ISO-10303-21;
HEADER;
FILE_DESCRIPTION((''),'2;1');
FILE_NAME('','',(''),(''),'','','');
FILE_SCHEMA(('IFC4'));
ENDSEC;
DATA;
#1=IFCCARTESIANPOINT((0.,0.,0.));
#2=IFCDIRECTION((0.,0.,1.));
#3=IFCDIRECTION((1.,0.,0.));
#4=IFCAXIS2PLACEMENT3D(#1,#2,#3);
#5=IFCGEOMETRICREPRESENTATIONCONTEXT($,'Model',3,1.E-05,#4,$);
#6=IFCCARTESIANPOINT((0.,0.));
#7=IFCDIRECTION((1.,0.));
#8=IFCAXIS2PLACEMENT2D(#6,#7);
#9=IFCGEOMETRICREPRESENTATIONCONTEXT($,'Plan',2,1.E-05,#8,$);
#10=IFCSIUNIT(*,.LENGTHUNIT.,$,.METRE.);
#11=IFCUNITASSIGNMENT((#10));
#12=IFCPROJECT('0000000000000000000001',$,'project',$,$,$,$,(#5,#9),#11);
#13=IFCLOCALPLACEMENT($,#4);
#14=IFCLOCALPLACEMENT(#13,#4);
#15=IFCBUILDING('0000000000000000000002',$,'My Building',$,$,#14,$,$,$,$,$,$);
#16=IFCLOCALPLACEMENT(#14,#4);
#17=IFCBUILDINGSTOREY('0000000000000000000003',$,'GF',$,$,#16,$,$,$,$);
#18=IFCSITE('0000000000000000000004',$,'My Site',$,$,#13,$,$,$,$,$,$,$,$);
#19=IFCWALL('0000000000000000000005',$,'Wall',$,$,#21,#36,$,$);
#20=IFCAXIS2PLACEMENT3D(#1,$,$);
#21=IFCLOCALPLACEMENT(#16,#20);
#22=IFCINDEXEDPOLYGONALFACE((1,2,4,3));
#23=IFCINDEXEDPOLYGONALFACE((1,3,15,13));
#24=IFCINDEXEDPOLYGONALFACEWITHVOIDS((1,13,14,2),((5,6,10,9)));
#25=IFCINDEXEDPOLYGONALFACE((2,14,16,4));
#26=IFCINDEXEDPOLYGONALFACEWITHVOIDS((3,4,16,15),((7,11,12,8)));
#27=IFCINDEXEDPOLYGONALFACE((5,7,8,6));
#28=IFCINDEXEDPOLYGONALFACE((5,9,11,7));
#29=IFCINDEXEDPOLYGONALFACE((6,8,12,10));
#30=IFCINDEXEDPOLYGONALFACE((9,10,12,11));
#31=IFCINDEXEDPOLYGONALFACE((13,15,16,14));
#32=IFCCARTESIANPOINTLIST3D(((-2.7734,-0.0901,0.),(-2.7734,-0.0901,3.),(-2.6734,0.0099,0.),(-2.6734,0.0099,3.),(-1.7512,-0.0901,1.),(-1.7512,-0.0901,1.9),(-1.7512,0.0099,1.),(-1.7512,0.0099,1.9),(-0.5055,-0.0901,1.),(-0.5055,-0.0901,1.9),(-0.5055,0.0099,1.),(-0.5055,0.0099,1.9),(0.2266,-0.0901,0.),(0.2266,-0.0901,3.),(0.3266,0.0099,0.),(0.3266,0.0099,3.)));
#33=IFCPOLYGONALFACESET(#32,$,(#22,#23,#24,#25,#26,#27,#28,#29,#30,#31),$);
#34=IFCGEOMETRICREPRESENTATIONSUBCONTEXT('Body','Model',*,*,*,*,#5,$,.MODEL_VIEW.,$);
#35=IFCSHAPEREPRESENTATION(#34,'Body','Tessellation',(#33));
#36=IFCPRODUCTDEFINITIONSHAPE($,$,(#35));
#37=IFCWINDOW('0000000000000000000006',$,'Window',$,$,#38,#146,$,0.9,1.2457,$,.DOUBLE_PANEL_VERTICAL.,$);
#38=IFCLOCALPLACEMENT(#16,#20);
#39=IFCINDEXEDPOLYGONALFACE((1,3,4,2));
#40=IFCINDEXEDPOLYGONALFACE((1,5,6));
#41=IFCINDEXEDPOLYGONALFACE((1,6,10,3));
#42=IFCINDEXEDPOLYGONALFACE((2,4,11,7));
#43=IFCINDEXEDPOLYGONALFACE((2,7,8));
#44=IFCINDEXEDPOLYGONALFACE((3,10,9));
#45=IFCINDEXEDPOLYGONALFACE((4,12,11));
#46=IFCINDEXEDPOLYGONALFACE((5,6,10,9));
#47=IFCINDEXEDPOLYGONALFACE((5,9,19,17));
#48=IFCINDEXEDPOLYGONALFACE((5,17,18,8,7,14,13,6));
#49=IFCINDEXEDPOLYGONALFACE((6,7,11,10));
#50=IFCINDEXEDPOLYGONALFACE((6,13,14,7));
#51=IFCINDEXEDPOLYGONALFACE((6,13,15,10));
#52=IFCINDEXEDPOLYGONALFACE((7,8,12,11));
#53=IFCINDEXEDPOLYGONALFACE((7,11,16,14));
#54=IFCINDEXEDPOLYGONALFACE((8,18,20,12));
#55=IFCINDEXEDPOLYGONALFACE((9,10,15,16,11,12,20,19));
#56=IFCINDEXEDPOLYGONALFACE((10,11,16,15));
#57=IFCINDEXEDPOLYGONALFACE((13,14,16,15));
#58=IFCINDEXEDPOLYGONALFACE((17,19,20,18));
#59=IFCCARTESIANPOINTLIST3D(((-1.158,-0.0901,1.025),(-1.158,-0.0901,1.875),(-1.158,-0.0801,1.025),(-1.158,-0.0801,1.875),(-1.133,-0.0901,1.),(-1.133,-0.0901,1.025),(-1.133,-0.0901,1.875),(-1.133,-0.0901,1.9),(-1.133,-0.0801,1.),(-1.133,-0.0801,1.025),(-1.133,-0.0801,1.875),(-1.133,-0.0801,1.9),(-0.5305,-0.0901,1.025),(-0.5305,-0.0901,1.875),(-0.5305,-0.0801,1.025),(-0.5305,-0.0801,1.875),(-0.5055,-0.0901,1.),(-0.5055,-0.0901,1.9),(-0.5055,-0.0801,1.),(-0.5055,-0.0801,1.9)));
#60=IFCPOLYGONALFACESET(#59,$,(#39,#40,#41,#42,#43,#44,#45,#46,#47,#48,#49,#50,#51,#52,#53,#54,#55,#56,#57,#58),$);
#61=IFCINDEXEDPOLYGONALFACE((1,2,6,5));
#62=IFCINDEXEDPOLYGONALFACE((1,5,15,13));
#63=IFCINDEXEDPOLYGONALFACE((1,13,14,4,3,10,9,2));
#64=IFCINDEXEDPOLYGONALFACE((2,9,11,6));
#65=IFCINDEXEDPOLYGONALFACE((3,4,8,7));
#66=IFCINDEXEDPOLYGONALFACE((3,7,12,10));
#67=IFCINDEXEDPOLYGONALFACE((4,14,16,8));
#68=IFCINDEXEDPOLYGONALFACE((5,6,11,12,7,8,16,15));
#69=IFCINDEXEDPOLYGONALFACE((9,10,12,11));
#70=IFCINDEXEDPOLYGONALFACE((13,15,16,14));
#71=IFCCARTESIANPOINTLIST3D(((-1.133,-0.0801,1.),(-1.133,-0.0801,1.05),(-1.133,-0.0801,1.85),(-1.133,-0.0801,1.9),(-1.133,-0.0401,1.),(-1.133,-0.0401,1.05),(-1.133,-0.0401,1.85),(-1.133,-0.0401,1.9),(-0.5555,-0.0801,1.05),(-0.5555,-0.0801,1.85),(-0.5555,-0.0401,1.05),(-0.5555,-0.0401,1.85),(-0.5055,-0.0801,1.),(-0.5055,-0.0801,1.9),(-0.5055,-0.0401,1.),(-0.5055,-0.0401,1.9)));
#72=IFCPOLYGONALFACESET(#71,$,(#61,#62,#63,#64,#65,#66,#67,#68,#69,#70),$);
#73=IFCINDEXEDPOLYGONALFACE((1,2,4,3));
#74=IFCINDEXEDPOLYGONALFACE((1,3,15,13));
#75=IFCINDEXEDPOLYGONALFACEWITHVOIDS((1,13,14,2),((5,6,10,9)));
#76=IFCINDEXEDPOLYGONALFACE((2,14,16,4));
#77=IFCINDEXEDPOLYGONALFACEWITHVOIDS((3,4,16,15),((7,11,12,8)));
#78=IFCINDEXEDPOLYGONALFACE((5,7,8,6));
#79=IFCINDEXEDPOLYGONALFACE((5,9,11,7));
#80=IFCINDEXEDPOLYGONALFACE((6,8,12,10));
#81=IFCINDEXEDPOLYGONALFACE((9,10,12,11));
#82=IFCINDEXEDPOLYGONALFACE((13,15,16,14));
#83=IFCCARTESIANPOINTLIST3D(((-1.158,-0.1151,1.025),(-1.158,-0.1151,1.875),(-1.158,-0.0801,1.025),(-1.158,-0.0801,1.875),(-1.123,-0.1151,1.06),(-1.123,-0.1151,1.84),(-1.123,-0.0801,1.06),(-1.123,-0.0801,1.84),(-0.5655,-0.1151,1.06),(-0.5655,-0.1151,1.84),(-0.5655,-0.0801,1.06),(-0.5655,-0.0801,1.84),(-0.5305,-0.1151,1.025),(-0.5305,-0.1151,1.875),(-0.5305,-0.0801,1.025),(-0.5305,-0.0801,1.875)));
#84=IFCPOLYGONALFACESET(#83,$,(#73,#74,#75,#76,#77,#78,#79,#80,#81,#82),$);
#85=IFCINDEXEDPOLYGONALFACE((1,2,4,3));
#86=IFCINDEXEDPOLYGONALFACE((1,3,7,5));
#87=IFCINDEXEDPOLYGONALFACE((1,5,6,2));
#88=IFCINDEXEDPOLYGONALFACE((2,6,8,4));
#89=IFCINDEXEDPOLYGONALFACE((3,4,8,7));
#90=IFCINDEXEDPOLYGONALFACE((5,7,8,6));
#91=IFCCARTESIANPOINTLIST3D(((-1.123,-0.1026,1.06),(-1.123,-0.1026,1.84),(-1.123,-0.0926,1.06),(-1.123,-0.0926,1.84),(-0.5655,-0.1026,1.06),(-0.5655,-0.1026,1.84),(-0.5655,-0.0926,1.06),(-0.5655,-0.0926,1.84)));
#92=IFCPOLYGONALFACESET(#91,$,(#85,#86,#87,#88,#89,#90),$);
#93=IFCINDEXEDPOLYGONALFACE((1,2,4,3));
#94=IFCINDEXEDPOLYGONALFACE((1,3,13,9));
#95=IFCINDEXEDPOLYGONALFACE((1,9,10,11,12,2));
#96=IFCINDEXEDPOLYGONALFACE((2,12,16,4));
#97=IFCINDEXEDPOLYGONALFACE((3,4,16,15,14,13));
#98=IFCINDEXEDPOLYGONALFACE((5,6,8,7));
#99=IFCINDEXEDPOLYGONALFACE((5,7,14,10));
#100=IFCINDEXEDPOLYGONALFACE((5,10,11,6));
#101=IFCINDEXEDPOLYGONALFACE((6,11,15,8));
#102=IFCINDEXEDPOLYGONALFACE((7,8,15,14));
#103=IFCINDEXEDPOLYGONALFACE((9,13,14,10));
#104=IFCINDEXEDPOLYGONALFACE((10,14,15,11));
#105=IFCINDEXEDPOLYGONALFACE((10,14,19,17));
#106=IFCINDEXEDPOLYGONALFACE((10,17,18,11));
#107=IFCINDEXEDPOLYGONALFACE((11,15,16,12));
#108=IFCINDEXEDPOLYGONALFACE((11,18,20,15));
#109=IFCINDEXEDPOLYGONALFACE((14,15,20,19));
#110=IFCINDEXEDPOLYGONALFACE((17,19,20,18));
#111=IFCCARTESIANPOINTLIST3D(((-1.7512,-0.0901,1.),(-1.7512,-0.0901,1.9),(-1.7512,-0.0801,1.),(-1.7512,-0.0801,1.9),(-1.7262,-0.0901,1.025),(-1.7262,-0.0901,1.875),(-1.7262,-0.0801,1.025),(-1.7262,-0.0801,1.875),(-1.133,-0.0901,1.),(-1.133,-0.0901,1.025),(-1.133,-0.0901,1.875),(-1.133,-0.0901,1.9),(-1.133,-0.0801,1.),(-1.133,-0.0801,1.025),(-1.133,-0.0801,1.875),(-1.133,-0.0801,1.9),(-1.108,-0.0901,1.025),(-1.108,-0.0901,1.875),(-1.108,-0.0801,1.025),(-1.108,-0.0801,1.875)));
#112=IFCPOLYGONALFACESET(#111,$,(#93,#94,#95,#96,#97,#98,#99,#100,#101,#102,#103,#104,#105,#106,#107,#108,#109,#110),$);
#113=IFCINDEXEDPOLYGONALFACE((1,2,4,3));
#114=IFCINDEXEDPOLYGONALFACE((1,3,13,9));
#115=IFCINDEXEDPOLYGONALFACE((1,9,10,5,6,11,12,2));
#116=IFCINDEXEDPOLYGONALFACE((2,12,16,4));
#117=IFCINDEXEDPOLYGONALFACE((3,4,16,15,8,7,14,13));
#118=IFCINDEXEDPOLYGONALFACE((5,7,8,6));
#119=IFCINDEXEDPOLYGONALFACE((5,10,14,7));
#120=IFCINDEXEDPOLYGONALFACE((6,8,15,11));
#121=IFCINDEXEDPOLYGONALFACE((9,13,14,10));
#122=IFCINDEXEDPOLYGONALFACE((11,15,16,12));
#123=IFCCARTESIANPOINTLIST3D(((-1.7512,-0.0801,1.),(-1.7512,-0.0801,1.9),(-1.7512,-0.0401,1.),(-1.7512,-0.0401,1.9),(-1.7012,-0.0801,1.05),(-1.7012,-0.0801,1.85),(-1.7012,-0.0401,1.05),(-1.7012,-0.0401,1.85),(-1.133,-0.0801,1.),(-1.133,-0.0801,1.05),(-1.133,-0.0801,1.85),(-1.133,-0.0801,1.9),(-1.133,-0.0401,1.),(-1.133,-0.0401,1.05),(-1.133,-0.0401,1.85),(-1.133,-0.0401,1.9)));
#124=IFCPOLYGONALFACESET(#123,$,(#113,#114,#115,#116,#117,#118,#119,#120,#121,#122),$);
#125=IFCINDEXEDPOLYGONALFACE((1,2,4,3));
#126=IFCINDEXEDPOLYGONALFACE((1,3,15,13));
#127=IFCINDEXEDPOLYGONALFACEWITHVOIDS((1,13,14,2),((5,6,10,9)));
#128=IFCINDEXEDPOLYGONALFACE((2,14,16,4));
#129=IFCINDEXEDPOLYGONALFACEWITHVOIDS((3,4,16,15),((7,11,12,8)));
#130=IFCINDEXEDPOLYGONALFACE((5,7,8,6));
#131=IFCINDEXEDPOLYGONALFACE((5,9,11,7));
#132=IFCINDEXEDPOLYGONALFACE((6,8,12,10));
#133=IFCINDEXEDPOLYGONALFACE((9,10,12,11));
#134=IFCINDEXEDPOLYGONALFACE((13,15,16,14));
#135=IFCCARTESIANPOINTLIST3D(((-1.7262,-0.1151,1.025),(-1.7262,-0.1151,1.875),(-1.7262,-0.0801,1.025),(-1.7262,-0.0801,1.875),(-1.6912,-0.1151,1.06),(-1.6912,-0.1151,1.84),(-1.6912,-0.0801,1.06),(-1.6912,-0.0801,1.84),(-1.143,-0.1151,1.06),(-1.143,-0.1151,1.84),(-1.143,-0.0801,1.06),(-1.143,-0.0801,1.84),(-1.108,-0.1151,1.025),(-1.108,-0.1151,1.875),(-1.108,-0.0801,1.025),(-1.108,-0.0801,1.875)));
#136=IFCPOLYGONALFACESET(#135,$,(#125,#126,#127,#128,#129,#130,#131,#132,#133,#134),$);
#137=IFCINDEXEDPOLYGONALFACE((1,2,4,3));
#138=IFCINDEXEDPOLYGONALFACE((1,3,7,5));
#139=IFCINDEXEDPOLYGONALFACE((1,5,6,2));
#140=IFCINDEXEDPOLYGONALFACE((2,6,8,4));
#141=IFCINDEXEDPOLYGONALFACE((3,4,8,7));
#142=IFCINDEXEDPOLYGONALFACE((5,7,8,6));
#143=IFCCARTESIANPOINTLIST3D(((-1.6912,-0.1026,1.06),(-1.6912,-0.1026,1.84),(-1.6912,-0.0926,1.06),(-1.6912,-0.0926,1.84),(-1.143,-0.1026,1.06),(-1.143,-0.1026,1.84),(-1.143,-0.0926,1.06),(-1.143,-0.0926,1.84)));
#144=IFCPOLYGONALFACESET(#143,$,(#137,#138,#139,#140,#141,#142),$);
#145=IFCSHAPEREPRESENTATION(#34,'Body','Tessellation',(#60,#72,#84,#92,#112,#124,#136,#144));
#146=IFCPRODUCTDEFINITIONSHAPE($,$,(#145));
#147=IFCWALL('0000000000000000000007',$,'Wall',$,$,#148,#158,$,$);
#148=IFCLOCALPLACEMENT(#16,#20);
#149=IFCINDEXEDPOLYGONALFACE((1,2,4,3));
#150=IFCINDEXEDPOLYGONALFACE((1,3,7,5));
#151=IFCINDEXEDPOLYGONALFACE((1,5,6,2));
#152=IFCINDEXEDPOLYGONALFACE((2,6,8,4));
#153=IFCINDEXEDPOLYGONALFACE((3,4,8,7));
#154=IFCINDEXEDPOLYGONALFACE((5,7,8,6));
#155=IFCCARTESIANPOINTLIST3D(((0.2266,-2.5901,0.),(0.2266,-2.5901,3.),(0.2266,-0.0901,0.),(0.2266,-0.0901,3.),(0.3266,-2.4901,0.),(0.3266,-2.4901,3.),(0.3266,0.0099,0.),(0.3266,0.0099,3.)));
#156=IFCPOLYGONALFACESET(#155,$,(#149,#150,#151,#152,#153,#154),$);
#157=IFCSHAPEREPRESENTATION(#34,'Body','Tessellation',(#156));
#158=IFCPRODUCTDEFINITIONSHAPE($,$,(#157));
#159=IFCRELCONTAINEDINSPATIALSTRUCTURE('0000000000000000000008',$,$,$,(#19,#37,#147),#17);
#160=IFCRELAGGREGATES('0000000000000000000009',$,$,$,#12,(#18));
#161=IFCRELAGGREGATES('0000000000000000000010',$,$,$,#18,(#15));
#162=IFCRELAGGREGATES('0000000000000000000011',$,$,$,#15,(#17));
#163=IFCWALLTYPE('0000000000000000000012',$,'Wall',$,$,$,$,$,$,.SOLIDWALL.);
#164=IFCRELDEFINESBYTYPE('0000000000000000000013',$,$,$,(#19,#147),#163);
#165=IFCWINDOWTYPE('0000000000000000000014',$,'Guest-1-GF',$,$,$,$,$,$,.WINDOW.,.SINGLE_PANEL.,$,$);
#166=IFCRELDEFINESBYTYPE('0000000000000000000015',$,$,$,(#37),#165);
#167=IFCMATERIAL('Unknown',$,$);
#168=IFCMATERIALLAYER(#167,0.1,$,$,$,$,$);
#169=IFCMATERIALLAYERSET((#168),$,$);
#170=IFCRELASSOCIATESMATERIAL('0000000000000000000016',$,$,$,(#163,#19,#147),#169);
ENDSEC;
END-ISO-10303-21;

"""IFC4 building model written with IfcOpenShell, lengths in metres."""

from ifc_helpers import new_model, entity, si_unit, frame, origin_with_axes, origin_2d_with_axis, place, context, subcontext, project, spatial, line, indexed_curve, outline, extrude, shape, source, transform, mapped, material, layer, layer_set, layer_usage, type_object, type_shapes, element, fill, save


model = new_model("IFC4")

# Units and contexts
model_context = context("Model", 3, precision=1e-05, world=origin_with_axes())
plan_context = context("Plan", 2, precision=1e-05, world=origin_2d_with_axis())
body_context_1 = subcontext(model_context, "Body", "Model", "MODEL_VIEW")
body_context_2 = subcontext(plan_context, "Body", "Plan", "PLAN_VIEW")
ifc_project = project(units=[si_unit("LENGTHUNIT", "METRE")], contexts=[model_context, plan_context])

# Site, building, storey
site_placement = place(None, origin_with_axes())
site = spatial("IfcSite", under=ifc_project, at=site_placement, Name="My Site")
building_placement = place(site_placement, origin_with_axes())
building = spatial("IfcBuilding", under=site, at=building_placement, Name="My Building")
storey_placement = place(building_placement, origin_with_axes())
storey = spatial("IfcBuildingStorey", under=building, at=storey_placement, Name="GF")

# Shared definitions
ifc_material = material(Name="Unknown")

# Shared definitions
ifc_layer_1 = layer(ifc_material, 0.1)
ifc_layer_set_1 = layer_set([ifc_layer_1])
wall_type = type_object("IfcWallType", Name="Wall", PredefinedType="SOLIDWALL", material=ifc_layer_set_1)

# Wall, opening, window
ifc_layer_usage_1 = layer_usage(ifc_layer_set_1, "AXIS2", "POSITIVE", 0.0)
wall_1_placement = place(storey_placement, frame((-2.7734, -0.0901, 0.0), z_axis=(0.0, 0.0, 1.0), x_axis=(1.0, 0.0, 0.0)))
wall_1 = element("IfcWall", 1, at=wall_1_placement, inside=storey, type_object=wall_type, material=ifc_layer_usage_1, Name="Wall", context=body_context_1, shape_type="SweptSolid", body=[
    extrude(outline(indexed_curve([(0.0, 0.0), (0.1, 0.1), (3.1, 0.1), (3.0, 0.0)], segments=[line(1, 2, 3, 4, 1)])), origin_with_axes(), (0.0, 0.0, 1.0), 3.0),
])
shared_shape_1 = source(origin_with_axes(), body_context_1, "Body", "SweptSolid", [
    extrude(outline(indexed_curve([(0.0, 0.0), (1.2457, 0.0), (1.2457, 0.9), (0.0, 0.9)], segments=[line(1, 2, 3, 4, 1)])), frame((0.0, -0.6, 0.0), z_axis=(0.0, -1.0, 0.0), x_axis=(1.0, 0.0, 0.0)), (0.0, 0.0, -1.0), 1.2),
])
opening_1_placement = place(wall_1_placement, frame((2.2679, 0.1, 1.0), z_axis=(0.0, 0.0, 1.0), x_axis=(-1.0, 0.000001, 0.0)))
opening_1 = element("IfcOpeningElement", 2, at=opening_1_placement, cuts=wall_1, PredefinedType="OPENING", context=body_context_1, shape_type="MappedRepresentation", body=[
    mapped(shared_shape_1, transform((0.0, 0.0, 0.0), x_axis=(1.0, 0.0, 0.0), y_axis=(0.0, 1.0, 0.0), z_axis=(0.0, 0.0, 1.0), scale=1.0)),
])
window_type_1 = type_object("IfcWindowType", Name="Guest-1-GF", PartitioningType="SINGLE_PANEL", PredefinedType="WINDOW")
shared_shape_2 = source(origin_with_axes(), body_context_1, "Body", "SweptSolid", [
    extrude(outline(indexed_curve([(0.0, 0.0), (0.6275, 0.0), (0.6275, 0.9), (0.0, 0.9)], segments=[line(1, 2, 3, 4, 1)]), holes=[indexed_curve([(0.025, 0.025), (0.6525, 0.025), (0.6525, 0.875), (0.025, 0.875)], segments=[line(1, 2, 3, 4, 1)])]), frame((0.0, 0.09, 0.0), z_axis=(0.0, -1.0, 0.0), x_axis=(1.0, 0.0, 0.0)), (0.0, 0.0, -1.0), 0.01),
    extrude(outline(indexed_curve([(0.6275, 0.0), (0.0, 0.0), (0.0, 0.9), (0.6275, 0.9), (0.6275, 0.85), (0.05, 0.85), (0.05, 0.05), (0.6275, 0.05)], segments=[line(1, 2, 3, 4, 5, 6, 7, 8, 1)])), frame((0.0, 0.05, 0.0), z_axis=(0.0, -1.0, 0.0), x_axis=(1.0, 0.0, 0.0)), (0.0, 0.0, -1.0), 0.04),
    extrude(outline(indexed_curve([(0.0, 0.0), (0.6275, 0.0), (0.6275, 0.85), (0.0, 0.85)], segments=[line(1, 2, 3, 4, 1)]), holes=[indexed_curve([(0.035, 0.035), (0.5925, 0.035), (0.5925, 0.815), (0.035, 0.815)], segments=[line(1, 2, 3, 4, 1)])]), frame((0.025, 0.09, 0.025), z_axis=(0.0, -1.0, 0.0), x_axis=(1.0, 0.0, 0.0)), (0.0, 0.0, -1.0), 0.035),
    extrude(outline(indexed_curve([(0.035, 0.035), (0.5925, 0.035), (0.5925, 0.815), (0.035, 0.815)], segments=[line(1, 2, 3, 4, 1)])), frame((0.025, 0.1025, 0.025), z_axis=(0.0, -1.0, 0.0), x_axis=(1.0, 0.0, 0.0)), (0.0, 0.0, -1.0), 0.01),
    extrude(outline(indexed_curve([(0.0, 0.0), (0.6181, 0.0), (0.6181, 0.9), (0.0, 0.9)], segments=[line(1, 2, 3, 4, 1)]), holes=[indexed_curve([(-0.025, 0.025), (0.5931, 0.025), (0.5931, 0.875), (-0.025, 0.875)], segments=[line(1, 2, 3, 4, 1)])]), frame((0.6275, 0.09, 0.0), z_axis=(0.0, -1.0, 0.0), x_axis=(1.0, 0.0, 0.0)), (0.0, 0.0, -1.0), 0.01),
    extrude(outline(indexed_curve([(0.0, 0.9), (0.6181, 0.9), (0.6181, 0.0), (0.0, 0.0), (0.0, 0.05), (0.5681, 0.05), (0.5681, 0.85), (0.0, 0.85)], segments=[line(1, 2, 3, 4, 5, 6, 7, 8, 1)])), frame((0.6275, 0.05, 0.0), z_axis=(0.0, -1.0, 0.0), x_axis=(1.0, 0.0, 0.0)), (0.0, 0.0, -1.0), 0.04),
    extrude(outline(indexed_curve([(0.0, 0.0), (0.6181, 0.0), (0.6181, 0.85), (0.0, 0.85)], segments=[line(1, 2, 3, 4, 1)]), holes=[indexed_curve([(0.035, 0.035), (0.5831, 0.035), (0.5831, 0.815), (0.035, 0.815)], segments=[line(1, 2, 3, 4, 1)])]), frame((0.6025, 0.09, 0.025), z_axis=(0.0, -1.0, 0.0), x_axis=(1.0, 0.0, 0.0)), (0.0, 0.0, -1.0), 0.035),
    extrude(outline(indexed_curve([(0.035, 0.035), (0.5831, 0.035), (0.5831, 0.815), (0.035, 0.815)], segments=[line(1, 2, 3, 4, 1)])), frame((0.6025, 0.1025, 0.025), z_axis=(0.0, -1.0, 0.0), x_axis=(1.0, 0.0, 0.0)), (0.0, 0.0, -1.0), 0.01),
])
shared_shape_3 = source(origin_with_axes(), body_context_2, "Body", "Curve2D", [
    entity("IfcIndexedPolyCurve", entity("IfcCartesianPointList2D", [[0.05, 0.05], [0.6275, 0.05]])),
    entity("IfcIndexedPolyCurve", entity("IfcCartesianPointList2D", [[0.0, 0.1], [0.025, 0.1], [0.025, 0.09], [0.05, 0.09], [0.05, 0.05], [0.0, 0.05]]), [entity("IfcLineIndex", [1, 2, 3, 4, 5, 6, 1])]),
    entity("IfcIndexedPolyCurve", entity("IfcCartesianPointList2D", [[0.6275, 0.1], [0.6525, 0.1], [0.6525, 0.09], [0.6275, 0.09], [0.6275, 0.05], [0.6275, 0.05]])),
    entity("IfcIndexedPolyCurve", entity("IfcCartesianPointList2D", [[0.025, 0.09], [0.06, 0.09], [0.06, 0.125], [0.025, 0.125]]), [entity("IfcLineIndex", [1, 2, 3, 4, 1])]),
    entity("IfcIndexedPolyCurve", entity("IfcCartesianPointList2D", [[0.6525, 0.09], [0.6175, 0.09], [0.6175, 0.125], [0.6525, 0.125]]), [entity("IfcLineIndex", [1, 2, 3, 4, 1])]),
    entity("IfcIndexedPolyCurve", entity("IfcCartesianPointList2D", [[0.06, 0.09], [0.6175, 0.09]])),
    entity("IfcIndexedPolyCurve", entity("IfcCartesianPointList2D", [[0.06, 0.125], [0.6175, 0.125]])),
    entity("IfcIndexedPolyCurve", entity("IfcCartesianPointList2D", [[0.06, 0.1075], [0.6175, 0.1075]])),
    entity("IfcIndexedPolyCurve", entity("IfcCartesianPointList2D", [[0.6275, 0.05], [1.1957, 0.05]])),
    entity("IfcIndexedPolyCurve", entity("IfcCartesianPointList2D", [[0.6275, 0.1], [0.6025, 0.1], [0.6025, 0.09], [0.6275, 0.09], [0.6275, 0.05], [0.6275, 0.05]])),
    entity("IfcIndexedPolyCurve", entity("IfcCartesianPointList2D", [[1.2457, 0.1], [1.2207, 0.1], [1.2207, 0.09], [1.1957, 0.09], [1.1957, 0.05], [1.2457, 0.05]]), [entity("IfcLineIndex", [1, 2, 3, 4, 5, 6, 1])]),
    entity("IfcIndexedPolyCurve", entity("IfcCartesianPointList2D", [[0.6025, 0.09], [0.6375, 0.09], [0.6375, 0.125], [0.6025, 0.125]]), [entity("IfcLineIndex", [1, 2, 3, 4, 1])]),
    entity("IfcIndexedPolyCurve", entity("IfcCartesianPointList2D", [[1.2207, 0.09], [1.1857, 0.09], [1.1857, 0.125], [1.2207, 0.125]]), [entity("IfcLineIndex", [1, 2, 3, 4, 1])]),
    entity("IfcIndexedPolyCurve", entity("IfcCartesianPointList2D", [[0.6375, 0.09], [1.1857, 0.09]])),
    entity("IfcIndexedPolyCurve", entity("IfcCartesianPointList2D", [[0.6375, 0.125], [1.1857, 0.125]])),
    entity("IfcIndexedPolyCurve", entity("IfcCartesianPointList2D", [[0.6375, 0.1075], [1.1857, 0.1075]])),
])
type_shapes(window_type_1, [shared_shape_2, shared_shape_3])
window_1_placement = place(opening_1_placement, origin_with_axes())
window_1 = element("IfcWindow", 3, at=window_1_placement, inside=storey, type_object=window_type_1, Name="Window", OverallHeight=0.9, OverallWidth=1.2457, PartitioningType="DOUBLE_PANEL_VERTICAL", shapes=[
    shape(body_context_1, "Body", "MappedRepresentation", [mapped(shared_shape_2, transform((0.0, 0.0, 0.0), x_axis=(1.0, 0.0, 0.0), y_axis=(0.0, 1.0, 0.0), z_axis=(0.0, 0.0, 1.0), scale=1.0))]),
    shape(body_context_2, "Body", "MappedRepresentation", [mapped(shared_shape_3, transform((0.0, 0.0, 0.0), x_axis=(1.0, 0.0, 0.0), y_axis=(0.0, 1.0, 0.0), z_axis=(0.0, 0.0, 1.0), scale=1.0))]),
])
fill(opening_1, window_1)

# Wall
ifc_layer_usage_2 = layer_usage(ifc_layer_set_1, "AXIS2", "POSITIVE", 0.0)
wall_2_placement = place(storey_placement, frame((0.2266, -0.0901, 0.0), z_axis=(0.0, 0.0, 1.0), x_axis=(-0.000001, -1.0, 0.0)))
element("IfcWall", 4, at=wall_2_placement, inside=storey, type_object=wall_type, material=ifc_layer_usage_2, Name="Wall", context=body_context_1, shape_type="SweptSolid", body=[
    extrude(outline(indexed_curve([(0.0, 0.0), (-0.1, 0.1), (2.4, 0.1), (2.5, 0.0)], segments=[line(1, 2, 3, 4, 1)])), origin_with_axes(), (0.0, 0.0, 1.0), 3.0),
])

save(model, "model.ifc")
